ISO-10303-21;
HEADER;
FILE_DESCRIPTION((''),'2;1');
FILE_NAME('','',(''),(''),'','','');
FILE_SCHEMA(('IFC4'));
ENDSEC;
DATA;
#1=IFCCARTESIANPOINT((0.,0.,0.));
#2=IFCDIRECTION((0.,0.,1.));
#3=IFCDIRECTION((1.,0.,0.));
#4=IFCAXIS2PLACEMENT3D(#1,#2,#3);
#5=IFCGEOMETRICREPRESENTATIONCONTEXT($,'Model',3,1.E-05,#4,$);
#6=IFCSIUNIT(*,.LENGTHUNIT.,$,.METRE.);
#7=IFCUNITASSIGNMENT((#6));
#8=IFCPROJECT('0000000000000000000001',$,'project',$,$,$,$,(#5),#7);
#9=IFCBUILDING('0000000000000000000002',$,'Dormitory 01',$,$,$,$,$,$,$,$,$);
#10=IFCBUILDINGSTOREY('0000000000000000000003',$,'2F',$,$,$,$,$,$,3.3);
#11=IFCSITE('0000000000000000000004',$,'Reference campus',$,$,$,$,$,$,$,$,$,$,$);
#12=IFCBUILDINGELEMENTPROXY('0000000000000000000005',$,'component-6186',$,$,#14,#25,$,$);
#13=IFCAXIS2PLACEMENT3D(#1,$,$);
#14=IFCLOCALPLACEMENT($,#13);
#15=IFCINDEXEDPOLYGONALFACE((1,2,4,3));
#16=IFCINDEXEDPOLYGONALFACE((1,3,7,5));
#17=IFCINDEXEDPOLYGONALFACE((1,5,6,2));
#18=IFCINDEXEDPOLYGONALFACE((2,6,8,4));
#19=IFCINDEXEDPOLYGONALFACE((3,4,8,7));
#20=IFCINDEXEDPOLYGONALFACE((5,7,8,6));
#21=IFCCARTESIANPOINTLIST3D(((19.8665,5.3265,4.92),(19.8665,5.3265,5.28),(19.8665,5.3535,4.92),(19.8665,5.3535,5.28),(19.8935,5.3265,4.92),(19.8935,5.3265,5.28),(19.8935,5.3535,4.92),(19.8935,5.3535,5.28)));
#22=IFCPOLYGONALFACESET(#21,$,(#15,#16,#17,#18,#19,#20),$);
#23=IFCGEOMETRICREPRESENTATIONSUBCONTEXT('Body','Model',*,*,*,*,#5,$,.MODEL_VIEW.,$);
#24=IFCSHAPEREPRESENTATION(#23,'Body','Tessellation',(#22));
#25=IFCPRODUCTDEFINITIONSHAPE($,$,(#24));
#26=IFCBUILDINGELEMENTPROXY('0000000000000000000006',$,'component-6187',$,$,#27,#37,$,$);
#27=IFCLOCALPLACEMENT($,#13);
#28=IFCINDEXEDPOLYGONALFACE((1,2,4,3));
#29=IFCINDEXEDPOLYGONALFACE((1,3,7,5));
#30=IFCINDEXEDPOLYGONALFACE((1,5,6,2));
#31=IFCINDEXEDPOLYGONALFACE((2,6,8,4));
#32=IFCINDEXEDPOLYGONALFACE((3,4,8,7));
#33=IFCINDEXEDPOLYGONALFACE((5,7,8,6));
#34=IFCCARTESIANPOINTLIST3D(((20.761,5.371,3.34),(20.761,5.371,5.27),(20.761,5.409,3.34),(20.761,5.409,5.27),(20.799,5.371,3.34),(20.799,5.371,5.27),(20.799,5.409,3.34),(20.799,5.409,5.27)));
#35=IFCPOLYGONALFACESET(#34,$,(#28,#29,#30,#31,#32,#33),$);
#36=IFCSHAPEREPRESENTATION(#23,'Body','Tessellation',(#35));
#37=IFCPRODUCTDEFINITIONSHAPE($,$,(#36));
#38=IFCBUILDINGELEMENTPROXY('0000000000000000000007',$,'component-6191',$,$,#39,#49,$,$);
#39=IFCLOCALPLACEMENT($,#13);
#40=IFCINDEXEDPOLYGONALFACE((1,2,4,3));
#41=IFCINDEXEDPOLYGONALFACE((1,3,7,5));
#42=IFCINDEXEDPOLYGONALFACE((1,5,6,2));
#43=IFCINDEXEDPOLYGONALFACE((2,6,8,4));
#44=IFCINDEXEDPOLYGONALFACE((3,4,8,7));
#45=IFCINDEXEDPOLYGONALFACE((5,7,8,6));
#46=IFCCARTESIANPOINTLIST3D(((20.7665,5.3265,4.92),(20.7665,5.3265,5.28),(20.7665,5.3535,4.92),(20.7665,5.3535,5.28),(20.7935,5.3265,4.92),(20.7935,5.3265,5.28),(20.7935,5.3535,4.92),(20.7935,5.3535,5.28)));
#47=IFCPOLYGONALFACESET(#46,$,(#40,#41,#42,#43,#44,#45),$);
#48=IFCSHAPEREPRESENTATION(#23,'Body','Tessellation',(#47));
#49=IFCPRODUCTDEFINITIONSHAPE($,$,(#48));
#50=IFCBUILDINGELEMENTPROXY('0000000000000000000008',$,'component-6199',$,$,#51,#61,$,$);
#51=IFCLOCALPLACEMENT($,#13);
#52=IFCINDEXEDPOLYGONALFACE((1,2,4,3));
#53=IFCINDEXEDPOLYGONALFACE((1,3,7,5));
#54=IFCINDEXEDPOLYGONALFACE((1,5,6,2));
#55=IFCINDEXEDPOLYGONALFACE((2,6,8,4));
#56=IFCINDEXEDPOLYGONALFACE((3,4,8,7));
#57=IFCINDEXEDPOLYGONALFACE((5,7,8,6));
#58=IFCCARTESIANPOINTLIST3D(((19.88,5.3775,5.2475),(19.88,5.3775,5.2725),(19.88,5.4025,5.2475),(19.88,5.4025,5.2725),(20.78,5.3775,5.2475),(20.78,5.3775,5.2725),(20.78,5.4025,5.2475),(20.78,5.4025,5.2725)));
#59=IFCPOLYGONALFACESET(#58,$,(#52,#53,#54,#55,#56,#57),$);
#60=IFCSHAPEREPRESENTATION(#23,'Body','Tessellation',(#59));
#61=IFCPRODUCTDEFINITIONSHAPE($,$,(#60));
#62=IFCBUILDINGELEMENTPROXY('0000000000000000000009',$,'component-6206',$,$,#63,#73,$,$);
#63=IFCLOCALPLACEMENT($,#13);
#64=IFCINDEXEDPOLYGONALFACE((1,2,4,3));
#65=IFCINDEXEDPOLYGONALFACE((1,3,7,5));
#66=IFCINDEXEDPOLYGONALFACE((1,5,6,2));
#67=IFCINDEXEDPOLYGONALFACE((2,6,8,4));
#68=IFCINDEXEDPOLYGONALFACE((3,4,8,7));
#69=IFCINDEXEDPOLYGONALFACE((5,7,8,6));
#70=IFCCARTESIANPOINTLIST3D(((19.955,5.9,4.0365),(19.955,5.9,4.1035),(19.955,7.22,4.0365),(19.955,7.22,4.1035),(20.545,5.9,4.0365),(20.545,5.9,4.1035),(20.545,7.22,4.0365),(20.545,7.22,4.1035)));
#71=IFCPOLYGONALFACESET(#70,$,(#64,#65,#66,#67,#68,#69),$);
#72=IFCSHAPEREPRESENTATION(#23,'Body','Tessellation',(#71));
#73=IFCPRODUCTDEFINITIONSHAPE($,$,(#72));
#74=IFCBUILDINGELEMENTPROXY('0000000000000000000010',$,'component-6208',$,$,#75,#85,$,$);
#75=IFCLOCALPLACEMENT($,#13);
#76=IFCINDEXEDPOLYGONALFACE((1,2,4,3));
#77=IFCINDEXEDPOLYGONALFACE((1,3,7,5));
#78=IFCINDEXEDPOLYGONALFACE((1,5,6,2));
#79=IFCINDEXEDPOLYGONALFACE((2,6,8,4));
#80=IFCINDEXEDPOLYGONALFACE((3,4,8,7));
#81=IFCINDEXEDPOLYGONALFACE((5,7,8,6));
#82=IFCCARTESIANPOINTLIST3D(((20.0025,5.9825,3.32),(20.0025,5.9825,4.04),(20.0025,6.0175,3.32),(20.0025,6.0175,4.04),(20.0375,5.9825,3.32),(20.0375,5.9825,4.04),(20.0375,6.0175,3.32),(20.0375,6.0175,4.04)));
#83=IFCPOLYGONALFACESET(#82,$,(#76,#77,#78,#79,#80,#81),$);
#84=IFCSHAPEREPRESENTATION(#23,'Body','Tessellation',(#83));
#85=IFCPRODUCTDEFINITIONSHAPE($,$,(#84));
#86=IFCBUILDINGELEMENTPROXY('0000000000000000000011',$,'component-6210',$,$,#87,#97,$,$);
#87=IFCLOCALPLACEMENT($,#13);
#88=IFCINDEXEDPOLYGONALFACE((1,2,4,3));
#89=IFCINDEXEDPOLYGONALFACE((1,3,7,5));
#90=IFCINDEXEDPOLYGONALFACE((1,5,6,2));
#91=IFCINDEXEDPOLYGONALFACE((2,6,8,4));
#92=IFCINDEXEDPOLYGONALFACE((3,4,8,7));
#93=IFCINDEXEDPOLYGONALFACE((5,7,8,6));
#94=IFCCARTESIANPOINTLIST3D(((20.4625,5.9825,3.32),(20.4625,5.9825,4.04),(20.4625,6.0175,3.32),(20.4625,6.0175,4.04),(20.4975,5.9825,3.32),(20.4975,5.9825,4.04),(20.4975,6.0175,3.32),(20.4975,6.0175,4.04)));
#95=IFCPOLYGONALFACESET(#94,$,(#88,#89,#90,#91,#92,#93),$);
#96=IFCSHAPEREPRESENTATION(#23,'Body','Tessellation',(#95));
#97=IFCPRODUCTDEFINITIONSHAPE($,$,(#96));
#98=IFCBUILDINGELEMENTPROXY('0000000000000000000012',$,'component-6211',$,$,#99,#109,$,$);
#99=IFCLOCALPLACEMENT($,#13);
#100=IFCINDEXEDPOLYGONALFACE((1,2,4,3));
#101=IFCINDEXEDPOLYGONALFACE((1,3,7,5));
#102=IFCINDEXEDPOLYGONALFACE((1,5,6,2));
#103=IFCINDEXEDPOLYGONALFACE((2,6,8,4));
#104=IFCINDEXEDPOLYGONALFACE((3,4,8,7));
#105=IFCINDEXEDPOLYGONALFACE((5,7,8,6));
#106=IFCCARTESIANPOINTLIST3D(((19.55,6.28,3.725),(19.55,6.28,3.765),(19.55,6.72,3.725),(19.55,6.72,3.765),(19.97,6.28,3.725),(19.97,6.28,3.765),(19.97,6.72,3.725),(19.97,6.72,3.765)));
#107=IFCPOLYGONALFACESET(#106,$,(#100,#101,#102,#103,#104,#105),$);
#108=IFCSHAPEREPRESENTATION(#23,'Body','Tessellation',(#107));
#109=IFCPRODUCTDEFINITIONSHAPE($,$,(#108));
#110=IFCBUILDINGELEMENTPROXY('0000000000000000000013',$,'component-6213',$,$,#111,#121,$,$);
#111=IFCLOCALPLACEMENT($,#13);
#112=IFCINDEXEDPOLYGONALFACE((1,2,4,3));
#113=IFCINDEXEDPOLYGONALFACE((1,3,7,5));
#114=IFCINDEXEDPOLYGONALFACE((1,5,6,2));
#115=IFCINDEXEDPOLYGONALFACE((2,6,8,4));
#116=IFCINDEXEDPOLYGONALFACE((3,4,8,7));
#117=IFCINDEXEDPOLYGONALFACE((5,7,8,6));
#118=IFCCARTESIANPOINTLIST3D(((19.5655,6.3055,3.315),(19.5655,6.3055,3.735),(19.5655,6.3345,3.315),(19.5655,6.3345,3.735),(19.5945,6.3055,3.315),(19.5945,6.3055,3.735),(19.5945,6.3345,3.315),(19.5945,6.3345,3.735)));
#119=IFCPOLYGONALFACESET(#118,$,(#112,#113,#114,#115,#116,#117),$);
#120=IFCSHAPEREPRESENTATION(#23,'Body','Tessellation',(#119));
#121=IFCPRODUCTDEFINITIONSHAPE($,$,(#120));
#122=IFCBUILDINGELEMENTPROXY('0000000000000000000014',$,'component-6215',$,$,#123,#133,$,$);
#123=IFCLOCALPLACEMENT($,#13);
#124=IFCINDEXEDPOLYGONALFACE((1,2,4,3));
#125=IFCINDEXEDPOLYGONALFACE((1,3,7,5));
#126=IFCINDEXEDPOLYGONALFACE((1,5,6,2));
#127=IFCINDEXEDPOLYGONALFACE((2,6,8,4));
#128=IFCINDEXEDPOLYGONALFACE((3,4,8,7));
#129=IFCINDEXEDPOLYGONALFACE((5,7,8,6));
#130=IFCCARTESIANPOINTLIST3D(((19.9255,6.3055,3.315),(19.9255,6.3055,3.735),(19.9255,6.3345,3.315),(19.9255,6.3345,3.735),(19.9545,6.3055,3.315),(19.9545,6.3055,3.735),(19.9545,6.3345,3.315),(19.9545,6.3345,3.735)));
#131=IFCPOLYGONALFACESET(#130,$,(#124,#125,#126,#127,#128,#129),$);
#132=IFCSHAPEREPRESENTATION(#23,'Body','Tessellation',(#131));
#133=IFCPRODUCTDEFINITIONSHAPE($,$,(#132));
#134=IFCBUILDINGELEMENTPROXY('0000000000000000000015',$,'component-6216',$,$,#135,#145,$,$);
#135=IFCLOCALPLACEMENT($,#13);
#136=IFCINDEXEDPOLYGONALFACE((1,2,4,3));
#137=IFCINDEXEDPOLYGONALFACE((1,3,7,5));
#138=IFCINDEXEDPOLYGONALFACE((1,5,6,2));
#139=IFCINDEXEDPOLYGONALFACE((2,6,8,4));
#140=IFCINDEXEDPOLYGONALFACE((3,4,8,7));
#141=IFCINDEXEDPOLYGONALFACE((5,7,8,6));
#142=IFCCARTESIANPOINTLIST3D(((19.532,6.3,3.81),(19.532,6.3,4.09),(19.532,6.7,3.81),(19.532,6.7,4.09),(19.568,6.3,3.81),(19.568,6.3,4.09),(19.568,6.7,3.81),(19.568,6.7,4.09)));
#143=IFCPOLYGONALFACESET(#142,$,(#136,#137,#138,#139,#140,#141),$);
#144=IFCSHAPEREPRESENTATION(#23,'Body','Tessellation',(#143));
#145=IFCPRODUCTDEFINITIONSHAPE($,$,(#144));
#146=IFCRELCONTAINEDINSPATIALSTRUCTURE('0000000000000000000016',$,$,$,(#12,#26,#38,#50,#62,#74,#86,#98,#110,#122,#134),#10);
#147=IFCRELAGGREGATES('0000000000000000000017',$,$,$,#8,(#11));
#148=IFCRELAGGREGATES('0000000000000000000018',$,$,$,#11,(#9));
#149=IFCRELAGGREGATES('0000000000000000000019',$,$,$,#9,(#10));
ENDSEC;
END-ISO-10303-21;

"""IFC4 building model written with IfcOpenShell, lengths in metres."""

from ifc_helpers import new_model, si_unit, frame, origin, origin_with_axes, origin_2d, place, context, subcontext, project, spatial, rectangle, extrude, element, save


model = new_model("IFC4")

# Units and contexts
model_context = context("Model", 3, precision=1e-05, world=origin_with_axes())
body_context = subcontext(model_context, "Body", "Model", "MODEL_VIEW")
ifc_project = project(units=[si_unit("LENGTHUNIT", "METRE")], contexts=[model_context])

# Site, building, storey
site = spatial("IfcSite", under=ifc_project, Name="Reference campus")
building = spatial("IfcBuilding", under=site, Name="Dormitory 01")
storey = spatial("IfcBuildingStorey", under=building, Name="2F", Elevation=3.3)

# Building element proxies
proxy_1_placement = place(None, frame((19.88, 5.34, 4.92), z_axis=(0.0, 0.0, 1.0), x_axis=(1.0, 0.0, 0.0)))
element("IfcBuildingElementProxy", 1, at=proxy_1_placement, inside=storey, Name="component-6186", context=body_context, shape_type="SweptSolid", body=[
    extrude(rectangle(XDim=0.027, YDim=0.027, at=origin_2d()), origin(), (0.0, 0.0, 1.0), 0.36),
])
proxy_2_placement = place(None, frame((20.78, 5.39, 3.34), z_axis=(0.0, 0.0, 1.0), x_axis=(1.0, 0.0, 0.0)))
element("IfcBuildingElementProxy", 2, at=proxy_2_placement, inside=storey, Name="component-6187", context=body_context, shape_type="SweptSolid", body=[
    extrude(rectangle(XDim=0.038, YDim=0.038, at=origin_2d()), origin(), (0.0, 0.0, 1.0), 1.93),
])
proxy_3_placement = place(None, frame((20.78, 5.34, 4.92), z_axis=(0.0, 0.0, 1.0), x_axis=(1.0, 0.0, 0.0)))
element("IfcBuildingElementProxy", 3, at=proxy_3_placement, inside=storey, Name="component-6191", context=body_context, shape_type="SweptSolid", body=[
    extrude(rectangle(XDim=0.027, YDim=0.027, at=origin_2d()), origin(), (0.0, 0.0, 1.0), 0.36),
])
proxy_4_placement = place(None, frame((20.33, 5.39, 5.2475), z_axis=(0.0, 0.0, 1.0), x_axis=(1.0, 0.0, 0.0)))
element("IfcBuildingElementProxy", 4, at=proxy_4_placement, inside=storey, Name="component-6199", context=body_context, shape_type="SweptSolid", body=[
    extrude(rectangle(XDim=0.9, YDim=0.025, at=origin_2d()), origin(), (0.0, 0.0, 1.0), 0.025),
])
proxy_5_placement = place(None, frame((20.25, 6.56, 4.0365), z_axis=(0.0, 0.0, 1.0), x_axis=(1.0, 0.0, 0.0)))
element("IfcBuildingElementProxy", 5, at=proxy_5_placement, inside=storey, Name="component-6206", context=body_context, shape_type="SweptSolid", body=[
    extrude(rectangle(XDim=0.59, YDim=1.32, at=origin_2d()), origin(), (0.0, 0.0, 1.0), 0.067),
])
for number, where, z_axis, x_axis, name in (
    (6, (20.02, 6.0, 3.32), (0.0, 0.0, 1.0), (1.0, 0.0, 0.0), "component-6208"),
    (7, (20.48, 6.0, 3.32), (0.0, 0.0, 1.0), (1.0, 0.0, 0.0), "component-6210"),
):
    element("IfcBuildingElementProxy", number, at=place(None, frame(where, z_axis=z_axis, x_axis=x_axis)), inside=storey, Name=name, context=body_context, shape_type="SweptSolid", body=[
        extrude(rectangle(XDim=0.035, YDim=0.035, at=origin_2d()), origin(), (0.0, 0.0, 1.0), 0.72),
    ])
proxy_6_placement = place(None, frame((19.76, 6.5, 3.725), z_axis=(0.0, 0.0, 1.0), x_axis=(1.0, 0.0, 0.0)))
element("IfcBuildingElementProxy", 8, at=proxy_6_placement, inside=storey, Name="component-6211", context=body_context, shape_type="SweptSolid", body=[
    extrude(rectangle(XDim=0.42, YDim=0.44, at=origin_2d()), origin(), (0.0, 0.0, 1.0), 0.04),
])
for number, where, z_axis, x_axis, name in (
    (9, (19.58, 6.32, 3.315), (0.0, 0.0, 1.0), (1.0, 0.0, 0.0), "component-6213"),
    (10, (19.94, 6.32, 3.315), (0.0, 0.0, 1.0), (1.0, 0.0, 0.0), "component-6215"),
):
    element("IfcBuildingElementProxy", number, at=place(None, frame(where, z_axis=z_axis, x_axis=x_axis)), inside=storey, Name=name, context=body_context, shape_type="SweptSolid", body=[
        extrude(rectangle(XDim=0.029, YDim=0.029, at=origin_2d()), origin(), (0.0, 0.0, 1.0), 0.42),
    ])
proxy_7_placement = place(None, frame((19.55, 6.5, 3.81), z_axis=(0.0, 0.0, 1.0), x_axis=(1.0, 0.0, 0.0)))
element("IfcBuildingElementProxy", 11, at=proxy_7_placement, inside=storey, Name="component-6216", context=body_context, shape_type="SweptSolid", body=[
    extrude(rectangle(XDim=0.036, YDim=0.4, at=origin_2d()), origin(), (0.0, 0.0, 1.0), 0.28),
])

save(model, "model.ifc")
